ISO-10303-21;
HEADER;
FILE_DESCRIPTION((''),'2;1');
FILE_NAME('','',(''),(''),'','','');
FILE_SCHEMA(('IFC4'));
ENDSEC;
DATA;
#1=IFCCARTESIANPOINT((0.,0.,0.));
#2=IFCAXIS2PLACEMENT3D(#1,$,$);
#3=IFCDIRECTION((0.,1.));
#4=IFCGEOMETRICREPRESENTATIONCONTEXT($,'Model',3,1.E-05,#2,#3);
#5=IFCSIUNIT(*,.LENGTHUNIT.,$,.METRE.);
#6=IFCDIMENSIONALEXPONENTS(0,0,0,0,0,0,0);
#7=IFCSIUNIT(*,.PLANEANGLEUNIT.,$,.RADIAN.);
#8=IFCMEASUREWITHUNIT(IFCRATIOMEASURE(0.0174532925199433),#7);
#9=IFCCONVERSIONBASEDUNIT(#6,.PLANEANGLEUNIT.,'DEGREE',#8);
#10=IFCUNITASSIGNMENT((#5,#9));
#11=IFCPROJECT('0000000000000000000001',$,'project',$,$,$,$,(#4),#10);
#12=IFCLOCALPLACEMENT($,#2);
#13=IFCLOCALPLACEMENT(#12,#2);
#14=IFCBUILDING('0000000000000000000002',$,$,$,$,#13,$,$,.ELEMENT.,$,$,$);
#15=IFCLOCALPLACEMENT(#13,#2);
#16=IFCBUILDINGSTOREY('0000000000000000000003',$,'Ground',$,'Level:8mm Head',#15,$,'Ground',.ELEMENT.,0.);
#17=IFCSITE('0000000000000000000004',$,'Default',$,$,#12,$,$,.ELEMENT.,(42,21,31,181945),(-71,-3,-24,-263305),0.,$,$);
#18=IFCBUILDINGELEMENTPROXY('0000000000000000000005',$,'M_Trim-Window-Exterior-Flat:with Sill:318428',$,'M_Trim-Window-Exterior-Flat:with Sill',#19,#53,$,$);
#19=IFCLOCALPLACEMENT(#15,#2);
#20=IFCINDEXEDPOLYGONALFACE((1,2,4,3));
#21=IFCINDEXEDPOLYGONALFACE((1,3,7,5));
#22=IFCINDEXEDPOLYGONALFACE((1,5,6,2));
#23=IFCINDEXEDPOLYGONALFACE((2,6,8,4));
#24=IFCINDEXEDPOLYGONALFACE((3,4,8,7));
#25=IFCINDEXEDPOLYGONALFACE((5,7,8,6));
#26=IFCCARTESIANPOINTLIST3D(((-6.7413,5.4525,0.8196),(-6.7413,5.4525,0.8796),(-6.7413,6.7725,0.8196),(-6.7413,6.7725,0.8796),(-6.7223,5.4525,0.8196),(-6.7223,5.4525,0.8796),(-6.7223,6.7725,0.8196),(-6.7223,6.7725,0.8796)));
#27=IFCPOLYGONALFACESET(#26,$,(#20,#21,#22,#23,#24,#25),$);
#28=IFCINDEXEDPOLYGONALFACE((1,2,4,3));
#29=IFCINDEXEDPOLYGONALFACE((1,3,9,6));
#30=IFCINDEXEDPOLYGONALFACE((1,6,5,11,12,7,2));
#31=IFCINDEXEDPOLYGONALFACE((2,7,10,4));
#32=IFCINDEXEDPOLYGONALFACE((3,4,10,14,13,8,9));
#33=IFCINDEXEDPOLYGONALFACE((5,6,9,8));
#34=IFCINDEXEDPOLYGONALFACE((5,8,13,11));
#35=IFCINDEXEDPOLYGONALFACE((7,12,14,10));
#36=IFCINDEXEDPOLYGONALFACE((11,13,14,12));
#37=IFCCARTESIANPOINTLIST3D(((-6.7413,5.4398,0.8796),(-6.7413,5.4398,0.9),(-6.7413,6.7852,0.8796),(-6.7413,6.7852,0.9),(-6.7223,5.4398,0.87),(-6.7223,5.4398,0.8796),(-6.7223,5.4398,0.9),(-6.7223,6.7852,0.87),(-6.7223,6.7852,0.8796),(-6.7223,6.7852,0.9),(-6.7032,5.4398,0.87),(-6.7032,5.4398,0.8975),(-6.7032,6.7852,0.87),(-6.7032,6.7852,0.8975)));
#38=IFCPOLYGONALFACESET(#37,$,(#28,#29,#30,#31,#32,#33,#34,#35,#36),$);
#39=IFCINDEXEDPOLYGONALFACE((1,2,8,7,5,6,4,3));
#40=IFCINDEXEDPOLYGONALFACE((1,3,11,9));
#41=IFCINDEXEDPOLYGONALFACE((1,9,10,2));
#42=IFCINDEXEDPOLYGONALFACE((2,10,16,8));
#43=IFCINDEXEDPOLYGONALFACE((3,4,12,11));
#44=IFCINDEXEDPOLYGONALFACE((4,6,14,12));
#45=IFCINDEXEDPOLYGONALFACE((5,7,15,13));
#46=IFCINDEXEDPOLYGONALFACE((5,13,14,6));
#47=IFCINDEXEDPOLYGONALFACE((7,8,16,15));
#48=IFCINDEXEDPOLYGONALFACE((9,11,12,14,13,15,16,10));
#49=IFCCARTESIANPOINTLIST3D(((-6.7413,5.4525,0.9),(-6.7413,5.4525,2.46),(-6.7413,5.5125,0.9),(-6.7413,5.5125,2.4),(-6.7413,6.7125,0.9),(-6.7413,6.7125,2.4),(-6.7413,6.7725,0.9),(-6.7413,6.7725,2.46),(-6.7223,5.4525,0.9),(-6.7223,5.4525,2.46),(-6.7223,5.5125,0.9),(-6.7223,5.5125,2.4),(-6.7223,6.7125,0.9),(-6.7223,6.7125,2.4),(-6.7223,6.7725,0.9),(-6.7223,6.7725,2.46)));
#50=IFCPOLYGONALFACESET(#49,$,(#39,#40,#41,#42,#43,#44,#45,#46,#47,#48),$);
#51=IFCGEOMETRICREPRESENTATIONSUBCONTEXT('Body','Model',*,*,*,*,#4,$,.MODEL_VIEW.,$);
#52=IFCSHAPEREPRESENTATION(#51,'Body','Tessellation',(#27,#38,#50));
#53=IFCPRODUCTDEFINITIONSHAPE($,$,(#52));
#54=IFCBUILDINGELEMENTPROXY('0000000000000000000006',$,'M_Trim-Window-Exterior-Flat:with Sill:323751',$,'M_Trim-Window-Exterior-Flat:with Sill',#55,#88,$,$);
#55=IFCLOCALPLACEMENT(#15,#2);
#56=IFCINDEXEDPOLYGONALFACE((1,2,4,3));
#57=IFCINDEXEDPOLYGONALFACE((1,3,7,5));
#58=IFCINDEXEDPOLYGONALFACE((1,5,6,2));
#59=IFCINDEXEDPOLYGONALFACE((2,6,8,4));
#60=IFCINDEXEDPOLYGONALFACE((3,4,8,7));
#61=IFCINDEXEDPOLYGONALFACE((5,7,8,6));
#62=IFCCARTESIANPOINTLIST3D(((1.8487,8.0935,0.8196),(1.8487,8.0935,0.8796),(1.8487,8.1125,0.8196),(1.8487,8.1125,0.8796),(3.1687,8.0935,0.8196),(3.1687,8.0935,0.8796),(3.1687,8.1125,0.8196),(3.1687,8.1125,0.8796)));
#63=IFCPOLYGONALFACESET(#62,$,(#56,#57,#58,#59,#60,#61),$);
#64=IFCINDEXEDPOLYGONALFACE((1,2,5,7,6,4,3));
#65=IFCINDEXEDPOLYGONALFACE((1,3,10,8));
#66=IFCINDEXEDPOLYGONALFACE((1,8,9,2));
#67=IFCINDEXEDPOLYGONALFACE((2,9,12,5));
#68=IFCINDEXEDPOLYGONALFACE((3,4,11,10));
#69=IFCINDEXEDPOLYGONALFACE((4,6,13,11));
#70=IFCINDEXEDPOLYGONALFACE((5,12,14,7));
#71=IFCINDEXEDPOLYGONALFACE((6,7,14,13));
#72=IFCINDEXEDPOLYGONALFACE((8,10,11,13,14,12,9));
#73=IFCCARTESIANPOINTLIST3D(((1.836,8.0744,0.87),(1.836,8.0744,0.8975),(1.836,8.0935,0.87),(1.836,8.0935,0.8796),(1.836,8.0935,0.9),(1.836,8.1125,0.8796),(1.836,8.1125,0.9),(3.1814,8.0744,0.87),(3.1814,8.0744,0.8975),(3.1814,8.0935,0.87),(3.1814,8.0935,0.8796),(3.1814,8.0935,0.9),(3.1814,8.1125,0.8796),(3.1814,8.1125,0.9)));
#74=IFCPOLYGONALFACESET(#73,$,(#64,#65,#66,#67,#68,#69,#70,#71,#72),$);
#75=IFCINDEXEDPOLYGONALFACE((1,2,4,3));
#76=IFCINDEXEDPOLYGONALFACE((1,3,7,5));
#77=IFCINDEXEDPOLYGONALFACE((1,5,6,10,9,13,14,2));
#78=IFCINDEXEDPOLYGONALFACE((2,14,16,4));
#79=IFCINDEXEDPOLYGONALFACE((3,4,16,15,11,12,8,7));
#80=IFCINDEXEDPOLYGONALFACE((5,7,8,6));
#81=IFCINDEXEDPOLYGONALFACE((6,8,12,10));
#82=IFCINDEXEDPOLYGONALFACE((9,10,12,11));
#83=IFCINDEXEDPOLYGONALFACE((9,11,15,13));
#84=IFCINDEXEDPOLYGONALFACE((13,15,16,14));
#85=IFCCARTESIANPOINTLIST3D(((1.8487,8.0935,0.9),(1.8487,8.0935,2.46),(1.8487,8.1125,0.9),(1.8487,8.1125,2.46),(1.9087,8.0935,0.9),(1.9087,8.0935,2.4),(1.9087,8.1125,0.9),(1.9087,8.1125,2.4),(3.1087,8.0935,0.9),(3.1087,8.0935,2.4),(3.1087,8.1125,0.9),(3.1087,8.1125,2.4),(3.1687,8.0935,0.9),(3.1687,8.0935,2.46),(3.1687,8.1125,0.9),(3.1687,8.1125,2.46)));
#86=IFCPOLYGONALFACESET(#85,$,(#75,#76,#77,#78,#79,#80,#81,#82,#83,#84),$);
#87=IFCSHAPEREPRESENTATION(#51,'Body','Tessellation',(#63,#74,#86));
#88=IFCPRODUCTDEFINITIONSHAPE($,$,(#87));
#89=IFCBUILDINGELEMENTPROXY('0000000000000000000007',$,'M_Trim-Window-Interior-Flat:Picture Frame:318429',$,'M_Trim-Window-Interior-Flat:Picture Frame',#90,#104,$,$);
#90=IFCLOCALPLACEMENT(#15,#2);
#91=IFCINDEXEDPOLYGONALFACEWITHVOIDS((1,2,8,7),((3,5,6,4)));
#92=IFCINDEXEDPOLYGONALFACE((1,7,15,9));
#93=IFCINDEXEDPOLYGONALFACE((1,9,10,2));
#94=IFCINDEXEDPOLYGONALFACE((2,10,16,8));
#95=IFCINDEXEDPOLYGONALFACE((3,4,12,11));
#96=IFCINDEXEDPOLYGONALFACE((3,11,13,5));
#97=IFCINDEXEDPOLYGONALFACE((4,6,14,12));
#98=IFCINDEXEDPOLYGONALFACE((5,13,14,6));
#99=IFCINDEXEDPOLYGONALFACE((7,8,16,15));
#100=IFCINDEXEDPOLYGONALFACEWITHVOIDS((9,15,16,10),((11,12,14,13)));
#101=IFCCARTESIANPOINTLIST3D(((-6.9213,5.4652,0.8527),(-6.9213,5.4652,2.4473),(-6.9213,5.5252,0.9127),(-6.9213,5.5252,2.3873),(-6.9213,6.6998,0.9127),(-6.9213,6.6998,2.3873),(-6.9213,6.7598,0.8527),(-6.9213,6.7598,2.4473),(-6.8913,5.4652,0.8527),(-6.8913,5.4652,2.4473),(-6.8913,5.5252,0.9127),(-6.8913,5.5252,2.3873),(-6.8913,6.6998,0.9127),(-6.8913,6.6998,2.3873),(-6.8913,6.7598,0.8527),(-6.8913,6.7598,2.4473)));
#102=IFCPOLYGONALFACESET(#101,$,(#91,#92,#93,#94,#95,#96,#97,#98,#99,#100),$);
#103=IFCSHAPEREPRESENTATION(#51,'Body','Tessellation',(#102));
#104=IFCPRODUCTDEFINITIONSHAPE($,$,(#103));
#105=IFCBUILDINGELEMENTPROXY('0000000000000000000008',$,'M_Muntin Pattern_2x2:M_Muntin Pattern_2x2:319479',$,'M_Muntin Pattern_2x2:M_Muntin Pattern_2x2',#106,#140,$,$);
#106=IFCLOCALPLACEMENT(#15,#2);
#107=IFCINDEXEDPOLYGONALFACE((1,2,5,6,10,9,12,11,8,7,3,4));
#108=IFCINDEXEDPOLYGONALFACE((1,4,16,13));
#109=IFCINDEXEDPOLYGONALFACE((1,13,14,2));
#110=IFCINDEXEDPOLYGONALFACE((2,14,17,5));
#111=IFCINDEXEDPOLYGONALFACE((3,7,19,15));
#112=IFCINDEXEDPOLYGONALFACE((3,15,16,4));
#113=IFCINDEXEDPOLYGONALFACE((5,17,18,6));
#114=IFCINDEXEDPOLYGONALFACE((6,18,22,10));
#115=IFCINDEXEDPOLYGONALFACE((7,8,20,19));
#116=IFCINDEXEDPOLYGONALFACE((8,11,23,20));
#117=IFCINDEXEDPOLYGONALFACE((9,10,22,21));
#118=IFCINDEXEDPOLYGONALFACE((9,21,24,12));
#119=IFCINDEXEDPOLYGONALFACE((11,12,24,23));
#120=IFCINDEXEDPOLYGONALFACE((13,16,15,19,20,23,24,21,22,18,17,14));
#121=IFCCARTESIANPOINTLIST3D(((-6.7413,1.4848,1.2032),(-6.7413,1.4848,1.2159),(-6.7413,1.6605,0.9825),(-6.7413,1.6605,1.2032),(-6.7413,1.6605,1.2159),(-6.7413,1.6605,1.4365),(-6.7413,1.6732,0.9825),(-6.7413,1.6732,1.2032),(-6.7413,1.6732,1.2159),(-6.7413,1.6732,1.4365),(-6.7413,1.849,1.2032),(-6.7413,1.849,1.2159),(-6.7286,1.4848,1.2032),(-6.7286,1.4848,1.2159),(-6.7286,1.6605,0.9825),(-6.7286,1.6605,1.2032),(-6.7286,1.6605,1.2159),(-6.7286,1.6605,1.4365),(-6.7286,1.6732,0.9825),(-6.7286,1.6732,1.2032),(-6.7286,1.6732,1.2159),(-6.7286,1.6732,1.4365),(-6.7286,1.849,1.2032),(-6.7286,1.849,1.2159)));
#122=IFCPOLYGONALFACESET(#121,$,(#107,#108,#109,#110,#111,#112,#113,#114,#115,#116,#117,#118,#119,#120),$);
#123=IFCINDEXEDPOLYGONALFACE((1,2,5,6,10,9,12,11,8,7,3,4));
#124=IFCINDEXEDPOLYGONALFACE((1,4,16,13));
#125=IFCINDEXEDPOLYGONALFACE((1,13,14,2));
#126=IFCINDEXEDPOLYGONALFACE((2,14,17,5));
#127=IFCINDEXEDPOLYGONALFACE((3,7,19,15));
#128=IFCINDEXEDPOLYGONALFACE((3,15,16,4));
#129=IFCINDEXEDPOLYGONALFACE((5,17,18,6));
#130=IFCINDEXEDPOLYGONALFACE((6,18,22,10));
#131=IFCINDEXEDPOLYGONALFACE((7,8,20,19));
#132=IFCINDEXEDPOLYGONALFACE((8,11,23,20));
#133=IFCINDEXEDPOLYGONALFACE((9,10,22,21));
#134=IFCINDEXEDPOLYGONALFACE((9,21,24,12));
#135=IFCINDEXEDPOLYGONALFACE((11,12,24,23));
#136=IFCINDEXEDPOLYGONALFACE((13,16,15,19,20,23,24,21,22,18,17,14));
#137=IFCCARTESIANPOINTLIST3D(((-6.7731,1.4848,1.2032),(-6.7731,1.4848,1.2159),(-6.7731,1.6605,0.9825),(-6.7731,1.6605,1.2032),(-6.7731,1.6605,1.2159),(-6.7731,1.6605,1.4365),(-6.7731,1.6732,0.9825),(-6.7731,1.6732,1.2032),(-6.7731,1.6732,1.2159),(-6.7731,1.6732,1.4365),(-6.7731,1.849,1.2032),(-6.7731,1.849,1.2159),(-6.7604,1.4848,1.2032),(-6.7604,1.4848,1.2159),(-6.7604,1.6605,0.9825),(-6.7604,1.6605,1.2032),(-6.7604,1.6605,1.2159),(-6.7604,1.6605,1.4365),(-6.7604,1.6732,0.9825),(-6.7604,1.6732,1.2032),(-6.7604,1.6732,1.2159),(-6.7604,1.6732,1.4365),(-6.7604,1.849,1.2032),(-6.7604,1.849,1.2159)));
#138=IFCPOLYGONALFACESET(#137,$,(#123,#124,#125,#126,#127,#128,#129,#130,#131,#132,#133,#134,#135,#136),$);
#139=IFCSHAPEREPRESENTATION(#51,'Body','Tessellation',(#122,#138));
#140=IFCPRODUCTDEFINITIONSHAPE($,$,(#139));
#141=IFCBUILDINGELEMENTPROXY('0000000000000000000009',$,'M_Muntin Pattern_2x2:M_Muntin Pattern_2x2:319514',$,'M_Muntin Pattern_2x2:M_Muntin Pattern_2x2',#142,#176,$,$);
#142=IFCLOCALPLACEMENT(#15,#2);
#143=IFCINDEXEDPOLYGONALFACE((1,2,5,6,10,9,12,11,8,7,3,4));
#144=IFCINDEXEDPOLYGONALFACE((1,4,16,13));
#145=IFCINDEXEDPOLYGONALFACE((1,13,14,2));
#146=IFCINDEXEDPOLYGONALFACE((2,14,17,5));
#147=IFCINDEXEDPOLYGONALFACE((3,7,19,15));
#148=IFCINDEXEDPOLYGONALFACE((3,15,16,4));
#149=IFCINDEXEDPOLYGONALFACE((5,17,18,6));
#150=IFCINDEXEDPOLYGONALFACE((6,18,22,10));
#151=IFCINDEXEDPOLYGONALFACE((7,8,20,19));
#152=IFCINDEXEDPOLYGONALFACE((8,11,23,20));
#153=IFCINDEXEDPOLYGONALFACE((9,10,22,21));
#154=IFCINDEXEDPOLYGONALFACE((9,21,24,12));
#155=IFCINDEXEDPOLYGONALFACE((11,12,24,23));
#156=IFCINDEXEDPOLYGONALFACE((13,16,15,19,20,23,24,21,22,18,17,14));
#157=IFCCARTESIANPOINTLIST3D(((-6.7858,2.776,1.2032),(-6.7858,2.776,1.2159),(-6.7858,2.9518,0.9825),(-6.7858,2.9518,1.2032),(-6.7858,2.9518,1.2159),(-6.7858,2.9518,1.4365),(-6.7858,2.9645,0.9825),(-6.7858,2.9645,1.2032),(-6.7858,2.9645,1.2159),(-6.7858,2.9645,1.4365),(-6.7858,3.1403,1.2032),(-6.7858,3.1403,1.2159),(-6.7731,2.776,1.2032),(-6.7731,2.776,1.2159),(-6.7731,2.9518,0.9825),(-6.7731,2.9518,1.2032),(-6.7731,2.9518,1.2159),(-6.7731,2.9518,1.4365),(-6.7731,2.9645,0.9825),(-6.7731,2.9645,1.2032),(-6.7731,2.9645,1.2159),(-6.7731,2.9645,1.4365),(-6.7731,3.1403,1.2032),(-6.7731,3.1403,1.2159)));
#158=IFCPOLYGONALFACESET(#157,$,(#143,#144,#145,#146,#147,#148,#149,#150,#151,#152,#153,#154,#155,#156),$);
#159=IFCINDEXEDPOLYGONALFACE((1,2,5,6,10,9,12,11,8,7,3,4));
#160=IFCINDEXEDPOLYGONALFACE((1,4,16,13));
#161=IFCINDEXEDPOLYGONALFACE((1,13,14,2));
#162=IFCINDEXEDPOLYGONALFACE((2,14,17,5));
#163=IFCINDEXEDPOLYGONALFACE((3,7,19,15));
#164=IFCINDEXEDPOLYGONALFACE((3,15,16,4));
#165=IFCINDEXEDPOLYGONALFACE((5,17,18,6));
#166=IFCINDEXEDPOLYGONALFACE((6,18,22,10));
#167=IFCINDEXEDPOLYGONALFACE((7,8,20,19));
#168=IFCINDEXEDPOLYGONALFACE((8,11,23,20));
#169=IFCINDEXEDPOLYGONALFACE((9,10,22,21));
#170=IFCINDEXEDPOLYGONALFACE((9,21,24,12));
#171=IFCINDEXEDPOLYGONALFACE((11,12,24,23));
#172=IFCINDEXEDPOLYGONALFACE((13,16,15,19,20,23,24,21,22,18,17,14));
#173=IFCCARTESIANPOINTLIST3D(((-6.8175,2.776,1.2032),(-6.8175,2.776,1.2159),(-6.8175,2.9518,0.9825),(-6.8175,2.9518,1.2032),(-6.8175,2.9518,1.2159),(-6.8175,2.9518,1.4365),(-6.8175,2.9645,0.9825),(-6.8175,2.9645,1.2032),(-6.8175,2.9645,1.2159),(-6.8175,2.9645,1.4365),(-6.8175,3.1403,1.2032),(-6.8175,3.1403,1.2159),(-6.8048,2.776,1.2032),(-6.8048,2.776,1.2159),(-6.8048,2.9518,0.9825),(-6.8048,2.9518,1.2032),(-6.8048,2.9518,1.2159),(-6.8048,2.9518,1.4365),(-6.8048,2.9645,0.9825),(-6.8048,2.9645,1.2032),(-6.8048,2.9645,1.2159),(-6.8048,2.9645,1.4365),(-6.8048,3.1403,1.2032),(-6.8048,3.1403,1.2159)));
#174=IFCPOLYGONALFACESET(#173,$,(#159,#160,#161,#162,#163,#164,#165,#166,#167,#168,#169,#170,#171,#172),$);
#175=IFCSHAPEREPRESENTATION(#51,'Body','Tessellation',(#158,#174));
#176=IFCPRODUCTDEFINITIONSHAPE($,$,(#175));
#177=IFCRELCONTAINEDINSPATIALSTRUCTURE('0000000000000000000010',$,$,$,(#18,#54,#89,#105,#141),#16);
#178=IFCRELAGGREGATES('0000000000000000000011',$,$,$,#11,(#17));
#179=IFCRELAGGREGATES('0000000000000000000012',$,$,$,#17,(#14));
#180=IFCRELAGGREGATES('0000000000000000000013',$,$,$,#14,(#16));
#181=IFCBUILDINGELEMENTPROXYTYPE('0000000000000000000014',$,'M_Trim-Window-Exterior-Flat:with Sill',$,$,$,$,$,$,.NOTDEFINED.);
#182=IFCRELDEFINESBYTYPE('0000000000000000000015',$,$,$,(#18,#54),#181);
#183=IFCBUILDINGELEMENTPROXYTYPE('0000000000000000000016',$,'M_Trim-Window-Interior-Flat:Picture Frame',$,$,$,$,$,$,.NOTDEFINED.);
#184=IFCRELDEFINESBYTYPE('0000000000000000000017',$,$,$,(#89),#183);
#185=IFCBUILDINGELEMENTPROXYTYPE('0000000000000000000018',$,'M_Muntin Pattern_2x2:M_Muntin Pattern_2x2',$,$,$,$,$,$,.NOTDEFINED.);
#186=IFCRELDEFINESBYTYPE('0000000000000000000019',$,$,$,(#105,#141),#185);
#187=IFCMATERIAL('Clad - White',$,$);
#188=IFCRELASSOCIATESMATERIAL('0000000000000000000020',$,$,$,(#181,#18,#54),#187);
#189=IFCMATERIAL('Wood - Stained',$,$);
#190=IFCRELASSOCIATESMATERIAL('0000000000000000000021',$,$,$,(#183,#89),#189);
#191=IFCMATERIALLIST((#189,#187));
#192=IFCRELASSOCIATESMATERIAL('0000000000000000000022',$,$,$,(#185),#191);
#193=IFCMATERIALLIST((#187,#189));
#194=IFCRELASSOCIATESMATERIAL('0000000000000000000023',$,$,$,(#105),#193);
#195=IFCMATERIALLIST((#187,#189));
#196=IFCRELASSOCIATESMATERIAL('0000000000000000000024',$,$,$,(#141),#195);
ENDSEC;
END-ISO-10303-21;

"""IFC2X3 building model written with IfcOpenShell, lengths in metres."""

from ifc_helpers import new_model, entity, si_unit, converted_unit, direction, frame, frame_2d, origin, place, context, subcontext, project, spatial, polyline, rectangle, outline, extrude, source, transform, mapped, material, material_list, type_object, type_shapes, element, save


model = new_model("IFC2X3")

# Units and contexts
model_context = context("Model", 3, precision=1e-05, world=origin(), true_north=direction((0.0, 1.0)))
body_context = subcontext(model_context, "Body", "Model", "MODEL_VIEW")
ifc_project = project(units=[si_unit("LENGTHUNIT", "METRE"), converted_unit("PLANEANGLEUNIT", "DEGREE", entity("IfcRatioMeasure", 0.0174532925199433), si_unit("PLANEANGLEUNIT", "RADIAN"), dimensions=[0, 0, 0, 0, 0, 0, 0])], contexts=[model_context])

# Site, building, storey
site_placement = place(None, origin())
site = spatial("IfcSite", under=ifc_project, at=site_placement, Name="Default", CompositionType="ELEMENT", RefLatitude=(42, 21, 31, 181945), RefLongitude=(-71, -3, -24, -263305), RefElevation=0.0)
building_placement = place(site_placement, origin())
building = spatial("IfcBuilding", under=site, at=building_placement, CompositionType="ELEMENT")
storey_placement = place(building_placement, origin())
storey = spatial("IfcBuildingStorey", under=building, at=storey_placement, Name="Ground", ObjectType="Level:8mm Head", LongName="Ground", CompositionType="ELEMENT", Elevation=0.0)

# Building element proxies
ifc_material_1 = material(Name="Clad - White")
ifc_material_2 = material(Name="Wood - Stained")
building_element_proxy_type_1 = type_object("IfcBuildingElementProxyType", Name="M_Trim-Window-Exterior-Flat:with Sill", PredefinedType="NOTDEFINED", material=ifc_material_1)
shared_shape_1 = source(origin(), body_context, "Body", "SweptSolid", [
    extrude(rectangle(XDim=1.32, YDim=0.06, at=frame_2d((0.0, 0.0), x_axis=(1.0, 0.0))), frame((0.0, -1.5504, 0.0), z_axis=(0.0, 0.0, 1.0), x_axis=(-1.0, 0.0, 0.0)), (0.0, 0.0, 1.0), 0.0191),
    extrude(outline(polyline([(-0.019, -0.0152), (0.0, -0.0152), (0.0, -0.0057), (0.019, -0.0057), (0.019, 0.0148), (0.0, 0.0148), (-0.019, 0.0123), (-0.019, -0.0152)])), frame((-0.6727, -1.5148, 0.019), z_axis=(1.0, 0.0, 0.0), x_axis=(0.0, 0.0, -1.0)), (0.0, 0.0, 1.0), 1.3454),
    extrude(outline(polyline([(-0.795, -0.66), (0.765, -0.66), (0.765, -0.6), (-0.735, -0.6), (-0.735, 0.6), (0.765, 0.6), (0.765, 0.66), (-0.795, 0.66), (-0.795, -0.66)])), frame((0.0, -0.735, 0.0), z_axis=(0.0, 0.0, 1.0), x_axis=(0.0, -1.0, 0.0)), (0.0, 0.0, 1.0), 0.0191),
])
type_shapes(building_element_proxy_type_1, [shared_shape_1])
for number, where, z_axis, x_axis, name in (
    (1, (-6.7413, 6.1125, 2.4), (1.0, 0.0, 0.0), (0.0, 1.0, 0.0), "M_Trim-Window-Exterior-Flat:with Sill:318428"),
    (2, (2.5087, 8.1125, 2.4), (0.0, -1.0, 0.0), (1.0, 0.0, 0.0), "M_Trim-Window-Exterior-Flat:with Sill:323751"),
):
    element("IfcBuildingElementProxy", number, at=place(storey_placement, frame(where, z_axis=z_axis, x_axis=x_axis)), inside=storey, type_object=building_element_proxy_type_1, material=ifc_material_1, Name=name, ObjectType="M_Trim-Window-Exterior-Flat:with Sill", context=body_context, shape_type="MappedRepresentation", body=[
        mapped(shared_shape_1, transform((0.0, 0.0, 0.0), scale=1.0)),
    ])
building_element_proxy_type_2 = type_object("IfcBuildingElementProxyType", Name="M_Trim-Window-Interior-Flat:Picture Frame", PredefinedType="NOTDEFINED", material=ifc_material_2)
shared_shape_2 = source(origin(), body_context, "Body", "SweptSolid", [
    extrude(outline(polyline([(-0.6473, -0.7973), (0.6473, -0.7973), (0.6473, 0.7973), (-0.6473, 0.7973), (-0.6473, -0.7973)]), holes=[polyline([(-0.5873, -0.7373), (-0.5873, 0.7373), (0.5873, 0.7373), (0.5873, -0.7373), (-0.5873, -0.7373)])]), frame((0.0, -0.75, 0.0), z_axis=(0.0, 0.0, 1.0), x_axis=(-1.0, 0.0, 0.0)), (0.0, 0.0, 1.0), 0.03),
])
type_shapes(building_element_proxy_type_2, [shared_shape_2])
proxy_1_placement = place(storey_placement, frame((-6.8913, 6.1125, 2.4), z_axis=(-1.0, 0.0, 0.0), x_axis=(0.0, -1.0, 0.0)))
element("IfcBuildingElementProxy", 3, at=proxy_1_placement, inside=storey, type_object=building_element_proxy_type_2, material=ifc_material_2, Name="M_Trim-Window-Interior-Flat:Picture Frame:318429", ObjectType="M_Trim-Window-Interior-Flat:Picture Frame", context=body_context, shape_type="MappedRepresentation", body=[
    mapped(shared_shape_2, transform((0.0, 0.0, 0.0), scale=1.0)),
])
ifc_material_list_1 = material_list([ifc_material_1, ifc_material_2])
ifc_material_list_2 = material_list([ifc_material_2, ifc_material_1])
building_element_proxy_type_3 = type_object("IfcBuildingElementProxyType", Name="M_Muntin Pattern_2x2:M_Muntin Pattern_2x2", PredefinedType="NOTDEFINED", material=ifc_material_list_2)
shared_shape_3 = source(origin(), body_context, "Body", "SweptSolid", [
    extrude(outline(polyline([(0.0064, -0.0064), (0.227, -0.0064), (0.227, 0.0063), (0.0064, 0.0063), (0.0064, 0.1821), (-0.0063, 0.1821), (-0.0063, 0.0063), (-0.227, 0.0063), (-0.227, -0.0064), (-0.0063, -0.0064), (-0.0063, -0.1821), (0.0064, -0.1821), (0.0064, -0.0064)])), frame((0.0, 0.0095, 0.227), z_axis=(0.0, 1.0, 0.0), x_axis=(0.0, 0.0, 1.0)), (0.0, 0.0, 1.0), 0.0127),
    extrude(outline(polyline([(0.0064, -0.0064), (0.227, -0.0064), (0.227, 0.0063), (0.0064, 0.0063), (0.0064, 0.1821), (-0.0063, 0.1821), (-0.0063, 0.0063), (-0.227, 0.0063), (-0.227, -0.0064), (-0.0063, -0.0064), (-0.0063, -0.1821), (0.0064, -0.1821), (0.0064, -0.0064)])), frame((0.0, -0.0222, 0.227), z_axis=(0.0, 1.0, 0.0), x_axis=(0.0, 0.0, 1.0)), (0.0, 0.0, 1.0), 0.0127),
])
type_shapes(building_element_proxy_type_3, [shared_shape_3])
proxy_2_placement = place(storey_placement, frame((-6.7509, 1.6669, 0.9825), z_axis=(0.0, 0.0, 1.0), x_axis=(0.0, -1.0, 0.0)))
element("IfcBuildingElementProxy", 4, at=proxy_2_placement, inside=storey, type_object=building_element_proxy_type_3, material=ifc_material_list_1, Name="M_Muntin Pattern_2x2:M_Muntin Pattern_2x2:319479", ObjectType="M_Muntin Pattern_2x2:M_Muntin Pattern_2x2", context=body_context, shape_type="MappedRepresentation", body=[
    mapped(shared_shape_3, transform((0.0, 0.0, 0.0), scale=1.0)),
])
ifc_material_list_3 = material_list([ifc_material_1, ifc_material_2])
proxy_3_placement = place(storey_placement, frame((-6.7953, 2.9582, 0.9825), z_axis=(0.0, 0.0, 1.0), x_axis=(0.0, -1.0, 0.0)))
element("IfcBuildingElementProxy", 5, at=proxy_3_placement, inside=storey, type_object=building_element_proxy_type_3, material=ifc_material_list_3, Name="M_Muntin Pattern_2x2:M_Muntin Pattern_2x2:319514", ObjectType="M_Muntin Pattern_2x2:M_Muntin Pattern_2x2", context=body_context, shape_type="MappedRepresentation", body=[
    mapped(shared_shape_3, transform((0.0, 0.0, 0.0), scale=1.0)),
])

save(model, "model.ifc")
